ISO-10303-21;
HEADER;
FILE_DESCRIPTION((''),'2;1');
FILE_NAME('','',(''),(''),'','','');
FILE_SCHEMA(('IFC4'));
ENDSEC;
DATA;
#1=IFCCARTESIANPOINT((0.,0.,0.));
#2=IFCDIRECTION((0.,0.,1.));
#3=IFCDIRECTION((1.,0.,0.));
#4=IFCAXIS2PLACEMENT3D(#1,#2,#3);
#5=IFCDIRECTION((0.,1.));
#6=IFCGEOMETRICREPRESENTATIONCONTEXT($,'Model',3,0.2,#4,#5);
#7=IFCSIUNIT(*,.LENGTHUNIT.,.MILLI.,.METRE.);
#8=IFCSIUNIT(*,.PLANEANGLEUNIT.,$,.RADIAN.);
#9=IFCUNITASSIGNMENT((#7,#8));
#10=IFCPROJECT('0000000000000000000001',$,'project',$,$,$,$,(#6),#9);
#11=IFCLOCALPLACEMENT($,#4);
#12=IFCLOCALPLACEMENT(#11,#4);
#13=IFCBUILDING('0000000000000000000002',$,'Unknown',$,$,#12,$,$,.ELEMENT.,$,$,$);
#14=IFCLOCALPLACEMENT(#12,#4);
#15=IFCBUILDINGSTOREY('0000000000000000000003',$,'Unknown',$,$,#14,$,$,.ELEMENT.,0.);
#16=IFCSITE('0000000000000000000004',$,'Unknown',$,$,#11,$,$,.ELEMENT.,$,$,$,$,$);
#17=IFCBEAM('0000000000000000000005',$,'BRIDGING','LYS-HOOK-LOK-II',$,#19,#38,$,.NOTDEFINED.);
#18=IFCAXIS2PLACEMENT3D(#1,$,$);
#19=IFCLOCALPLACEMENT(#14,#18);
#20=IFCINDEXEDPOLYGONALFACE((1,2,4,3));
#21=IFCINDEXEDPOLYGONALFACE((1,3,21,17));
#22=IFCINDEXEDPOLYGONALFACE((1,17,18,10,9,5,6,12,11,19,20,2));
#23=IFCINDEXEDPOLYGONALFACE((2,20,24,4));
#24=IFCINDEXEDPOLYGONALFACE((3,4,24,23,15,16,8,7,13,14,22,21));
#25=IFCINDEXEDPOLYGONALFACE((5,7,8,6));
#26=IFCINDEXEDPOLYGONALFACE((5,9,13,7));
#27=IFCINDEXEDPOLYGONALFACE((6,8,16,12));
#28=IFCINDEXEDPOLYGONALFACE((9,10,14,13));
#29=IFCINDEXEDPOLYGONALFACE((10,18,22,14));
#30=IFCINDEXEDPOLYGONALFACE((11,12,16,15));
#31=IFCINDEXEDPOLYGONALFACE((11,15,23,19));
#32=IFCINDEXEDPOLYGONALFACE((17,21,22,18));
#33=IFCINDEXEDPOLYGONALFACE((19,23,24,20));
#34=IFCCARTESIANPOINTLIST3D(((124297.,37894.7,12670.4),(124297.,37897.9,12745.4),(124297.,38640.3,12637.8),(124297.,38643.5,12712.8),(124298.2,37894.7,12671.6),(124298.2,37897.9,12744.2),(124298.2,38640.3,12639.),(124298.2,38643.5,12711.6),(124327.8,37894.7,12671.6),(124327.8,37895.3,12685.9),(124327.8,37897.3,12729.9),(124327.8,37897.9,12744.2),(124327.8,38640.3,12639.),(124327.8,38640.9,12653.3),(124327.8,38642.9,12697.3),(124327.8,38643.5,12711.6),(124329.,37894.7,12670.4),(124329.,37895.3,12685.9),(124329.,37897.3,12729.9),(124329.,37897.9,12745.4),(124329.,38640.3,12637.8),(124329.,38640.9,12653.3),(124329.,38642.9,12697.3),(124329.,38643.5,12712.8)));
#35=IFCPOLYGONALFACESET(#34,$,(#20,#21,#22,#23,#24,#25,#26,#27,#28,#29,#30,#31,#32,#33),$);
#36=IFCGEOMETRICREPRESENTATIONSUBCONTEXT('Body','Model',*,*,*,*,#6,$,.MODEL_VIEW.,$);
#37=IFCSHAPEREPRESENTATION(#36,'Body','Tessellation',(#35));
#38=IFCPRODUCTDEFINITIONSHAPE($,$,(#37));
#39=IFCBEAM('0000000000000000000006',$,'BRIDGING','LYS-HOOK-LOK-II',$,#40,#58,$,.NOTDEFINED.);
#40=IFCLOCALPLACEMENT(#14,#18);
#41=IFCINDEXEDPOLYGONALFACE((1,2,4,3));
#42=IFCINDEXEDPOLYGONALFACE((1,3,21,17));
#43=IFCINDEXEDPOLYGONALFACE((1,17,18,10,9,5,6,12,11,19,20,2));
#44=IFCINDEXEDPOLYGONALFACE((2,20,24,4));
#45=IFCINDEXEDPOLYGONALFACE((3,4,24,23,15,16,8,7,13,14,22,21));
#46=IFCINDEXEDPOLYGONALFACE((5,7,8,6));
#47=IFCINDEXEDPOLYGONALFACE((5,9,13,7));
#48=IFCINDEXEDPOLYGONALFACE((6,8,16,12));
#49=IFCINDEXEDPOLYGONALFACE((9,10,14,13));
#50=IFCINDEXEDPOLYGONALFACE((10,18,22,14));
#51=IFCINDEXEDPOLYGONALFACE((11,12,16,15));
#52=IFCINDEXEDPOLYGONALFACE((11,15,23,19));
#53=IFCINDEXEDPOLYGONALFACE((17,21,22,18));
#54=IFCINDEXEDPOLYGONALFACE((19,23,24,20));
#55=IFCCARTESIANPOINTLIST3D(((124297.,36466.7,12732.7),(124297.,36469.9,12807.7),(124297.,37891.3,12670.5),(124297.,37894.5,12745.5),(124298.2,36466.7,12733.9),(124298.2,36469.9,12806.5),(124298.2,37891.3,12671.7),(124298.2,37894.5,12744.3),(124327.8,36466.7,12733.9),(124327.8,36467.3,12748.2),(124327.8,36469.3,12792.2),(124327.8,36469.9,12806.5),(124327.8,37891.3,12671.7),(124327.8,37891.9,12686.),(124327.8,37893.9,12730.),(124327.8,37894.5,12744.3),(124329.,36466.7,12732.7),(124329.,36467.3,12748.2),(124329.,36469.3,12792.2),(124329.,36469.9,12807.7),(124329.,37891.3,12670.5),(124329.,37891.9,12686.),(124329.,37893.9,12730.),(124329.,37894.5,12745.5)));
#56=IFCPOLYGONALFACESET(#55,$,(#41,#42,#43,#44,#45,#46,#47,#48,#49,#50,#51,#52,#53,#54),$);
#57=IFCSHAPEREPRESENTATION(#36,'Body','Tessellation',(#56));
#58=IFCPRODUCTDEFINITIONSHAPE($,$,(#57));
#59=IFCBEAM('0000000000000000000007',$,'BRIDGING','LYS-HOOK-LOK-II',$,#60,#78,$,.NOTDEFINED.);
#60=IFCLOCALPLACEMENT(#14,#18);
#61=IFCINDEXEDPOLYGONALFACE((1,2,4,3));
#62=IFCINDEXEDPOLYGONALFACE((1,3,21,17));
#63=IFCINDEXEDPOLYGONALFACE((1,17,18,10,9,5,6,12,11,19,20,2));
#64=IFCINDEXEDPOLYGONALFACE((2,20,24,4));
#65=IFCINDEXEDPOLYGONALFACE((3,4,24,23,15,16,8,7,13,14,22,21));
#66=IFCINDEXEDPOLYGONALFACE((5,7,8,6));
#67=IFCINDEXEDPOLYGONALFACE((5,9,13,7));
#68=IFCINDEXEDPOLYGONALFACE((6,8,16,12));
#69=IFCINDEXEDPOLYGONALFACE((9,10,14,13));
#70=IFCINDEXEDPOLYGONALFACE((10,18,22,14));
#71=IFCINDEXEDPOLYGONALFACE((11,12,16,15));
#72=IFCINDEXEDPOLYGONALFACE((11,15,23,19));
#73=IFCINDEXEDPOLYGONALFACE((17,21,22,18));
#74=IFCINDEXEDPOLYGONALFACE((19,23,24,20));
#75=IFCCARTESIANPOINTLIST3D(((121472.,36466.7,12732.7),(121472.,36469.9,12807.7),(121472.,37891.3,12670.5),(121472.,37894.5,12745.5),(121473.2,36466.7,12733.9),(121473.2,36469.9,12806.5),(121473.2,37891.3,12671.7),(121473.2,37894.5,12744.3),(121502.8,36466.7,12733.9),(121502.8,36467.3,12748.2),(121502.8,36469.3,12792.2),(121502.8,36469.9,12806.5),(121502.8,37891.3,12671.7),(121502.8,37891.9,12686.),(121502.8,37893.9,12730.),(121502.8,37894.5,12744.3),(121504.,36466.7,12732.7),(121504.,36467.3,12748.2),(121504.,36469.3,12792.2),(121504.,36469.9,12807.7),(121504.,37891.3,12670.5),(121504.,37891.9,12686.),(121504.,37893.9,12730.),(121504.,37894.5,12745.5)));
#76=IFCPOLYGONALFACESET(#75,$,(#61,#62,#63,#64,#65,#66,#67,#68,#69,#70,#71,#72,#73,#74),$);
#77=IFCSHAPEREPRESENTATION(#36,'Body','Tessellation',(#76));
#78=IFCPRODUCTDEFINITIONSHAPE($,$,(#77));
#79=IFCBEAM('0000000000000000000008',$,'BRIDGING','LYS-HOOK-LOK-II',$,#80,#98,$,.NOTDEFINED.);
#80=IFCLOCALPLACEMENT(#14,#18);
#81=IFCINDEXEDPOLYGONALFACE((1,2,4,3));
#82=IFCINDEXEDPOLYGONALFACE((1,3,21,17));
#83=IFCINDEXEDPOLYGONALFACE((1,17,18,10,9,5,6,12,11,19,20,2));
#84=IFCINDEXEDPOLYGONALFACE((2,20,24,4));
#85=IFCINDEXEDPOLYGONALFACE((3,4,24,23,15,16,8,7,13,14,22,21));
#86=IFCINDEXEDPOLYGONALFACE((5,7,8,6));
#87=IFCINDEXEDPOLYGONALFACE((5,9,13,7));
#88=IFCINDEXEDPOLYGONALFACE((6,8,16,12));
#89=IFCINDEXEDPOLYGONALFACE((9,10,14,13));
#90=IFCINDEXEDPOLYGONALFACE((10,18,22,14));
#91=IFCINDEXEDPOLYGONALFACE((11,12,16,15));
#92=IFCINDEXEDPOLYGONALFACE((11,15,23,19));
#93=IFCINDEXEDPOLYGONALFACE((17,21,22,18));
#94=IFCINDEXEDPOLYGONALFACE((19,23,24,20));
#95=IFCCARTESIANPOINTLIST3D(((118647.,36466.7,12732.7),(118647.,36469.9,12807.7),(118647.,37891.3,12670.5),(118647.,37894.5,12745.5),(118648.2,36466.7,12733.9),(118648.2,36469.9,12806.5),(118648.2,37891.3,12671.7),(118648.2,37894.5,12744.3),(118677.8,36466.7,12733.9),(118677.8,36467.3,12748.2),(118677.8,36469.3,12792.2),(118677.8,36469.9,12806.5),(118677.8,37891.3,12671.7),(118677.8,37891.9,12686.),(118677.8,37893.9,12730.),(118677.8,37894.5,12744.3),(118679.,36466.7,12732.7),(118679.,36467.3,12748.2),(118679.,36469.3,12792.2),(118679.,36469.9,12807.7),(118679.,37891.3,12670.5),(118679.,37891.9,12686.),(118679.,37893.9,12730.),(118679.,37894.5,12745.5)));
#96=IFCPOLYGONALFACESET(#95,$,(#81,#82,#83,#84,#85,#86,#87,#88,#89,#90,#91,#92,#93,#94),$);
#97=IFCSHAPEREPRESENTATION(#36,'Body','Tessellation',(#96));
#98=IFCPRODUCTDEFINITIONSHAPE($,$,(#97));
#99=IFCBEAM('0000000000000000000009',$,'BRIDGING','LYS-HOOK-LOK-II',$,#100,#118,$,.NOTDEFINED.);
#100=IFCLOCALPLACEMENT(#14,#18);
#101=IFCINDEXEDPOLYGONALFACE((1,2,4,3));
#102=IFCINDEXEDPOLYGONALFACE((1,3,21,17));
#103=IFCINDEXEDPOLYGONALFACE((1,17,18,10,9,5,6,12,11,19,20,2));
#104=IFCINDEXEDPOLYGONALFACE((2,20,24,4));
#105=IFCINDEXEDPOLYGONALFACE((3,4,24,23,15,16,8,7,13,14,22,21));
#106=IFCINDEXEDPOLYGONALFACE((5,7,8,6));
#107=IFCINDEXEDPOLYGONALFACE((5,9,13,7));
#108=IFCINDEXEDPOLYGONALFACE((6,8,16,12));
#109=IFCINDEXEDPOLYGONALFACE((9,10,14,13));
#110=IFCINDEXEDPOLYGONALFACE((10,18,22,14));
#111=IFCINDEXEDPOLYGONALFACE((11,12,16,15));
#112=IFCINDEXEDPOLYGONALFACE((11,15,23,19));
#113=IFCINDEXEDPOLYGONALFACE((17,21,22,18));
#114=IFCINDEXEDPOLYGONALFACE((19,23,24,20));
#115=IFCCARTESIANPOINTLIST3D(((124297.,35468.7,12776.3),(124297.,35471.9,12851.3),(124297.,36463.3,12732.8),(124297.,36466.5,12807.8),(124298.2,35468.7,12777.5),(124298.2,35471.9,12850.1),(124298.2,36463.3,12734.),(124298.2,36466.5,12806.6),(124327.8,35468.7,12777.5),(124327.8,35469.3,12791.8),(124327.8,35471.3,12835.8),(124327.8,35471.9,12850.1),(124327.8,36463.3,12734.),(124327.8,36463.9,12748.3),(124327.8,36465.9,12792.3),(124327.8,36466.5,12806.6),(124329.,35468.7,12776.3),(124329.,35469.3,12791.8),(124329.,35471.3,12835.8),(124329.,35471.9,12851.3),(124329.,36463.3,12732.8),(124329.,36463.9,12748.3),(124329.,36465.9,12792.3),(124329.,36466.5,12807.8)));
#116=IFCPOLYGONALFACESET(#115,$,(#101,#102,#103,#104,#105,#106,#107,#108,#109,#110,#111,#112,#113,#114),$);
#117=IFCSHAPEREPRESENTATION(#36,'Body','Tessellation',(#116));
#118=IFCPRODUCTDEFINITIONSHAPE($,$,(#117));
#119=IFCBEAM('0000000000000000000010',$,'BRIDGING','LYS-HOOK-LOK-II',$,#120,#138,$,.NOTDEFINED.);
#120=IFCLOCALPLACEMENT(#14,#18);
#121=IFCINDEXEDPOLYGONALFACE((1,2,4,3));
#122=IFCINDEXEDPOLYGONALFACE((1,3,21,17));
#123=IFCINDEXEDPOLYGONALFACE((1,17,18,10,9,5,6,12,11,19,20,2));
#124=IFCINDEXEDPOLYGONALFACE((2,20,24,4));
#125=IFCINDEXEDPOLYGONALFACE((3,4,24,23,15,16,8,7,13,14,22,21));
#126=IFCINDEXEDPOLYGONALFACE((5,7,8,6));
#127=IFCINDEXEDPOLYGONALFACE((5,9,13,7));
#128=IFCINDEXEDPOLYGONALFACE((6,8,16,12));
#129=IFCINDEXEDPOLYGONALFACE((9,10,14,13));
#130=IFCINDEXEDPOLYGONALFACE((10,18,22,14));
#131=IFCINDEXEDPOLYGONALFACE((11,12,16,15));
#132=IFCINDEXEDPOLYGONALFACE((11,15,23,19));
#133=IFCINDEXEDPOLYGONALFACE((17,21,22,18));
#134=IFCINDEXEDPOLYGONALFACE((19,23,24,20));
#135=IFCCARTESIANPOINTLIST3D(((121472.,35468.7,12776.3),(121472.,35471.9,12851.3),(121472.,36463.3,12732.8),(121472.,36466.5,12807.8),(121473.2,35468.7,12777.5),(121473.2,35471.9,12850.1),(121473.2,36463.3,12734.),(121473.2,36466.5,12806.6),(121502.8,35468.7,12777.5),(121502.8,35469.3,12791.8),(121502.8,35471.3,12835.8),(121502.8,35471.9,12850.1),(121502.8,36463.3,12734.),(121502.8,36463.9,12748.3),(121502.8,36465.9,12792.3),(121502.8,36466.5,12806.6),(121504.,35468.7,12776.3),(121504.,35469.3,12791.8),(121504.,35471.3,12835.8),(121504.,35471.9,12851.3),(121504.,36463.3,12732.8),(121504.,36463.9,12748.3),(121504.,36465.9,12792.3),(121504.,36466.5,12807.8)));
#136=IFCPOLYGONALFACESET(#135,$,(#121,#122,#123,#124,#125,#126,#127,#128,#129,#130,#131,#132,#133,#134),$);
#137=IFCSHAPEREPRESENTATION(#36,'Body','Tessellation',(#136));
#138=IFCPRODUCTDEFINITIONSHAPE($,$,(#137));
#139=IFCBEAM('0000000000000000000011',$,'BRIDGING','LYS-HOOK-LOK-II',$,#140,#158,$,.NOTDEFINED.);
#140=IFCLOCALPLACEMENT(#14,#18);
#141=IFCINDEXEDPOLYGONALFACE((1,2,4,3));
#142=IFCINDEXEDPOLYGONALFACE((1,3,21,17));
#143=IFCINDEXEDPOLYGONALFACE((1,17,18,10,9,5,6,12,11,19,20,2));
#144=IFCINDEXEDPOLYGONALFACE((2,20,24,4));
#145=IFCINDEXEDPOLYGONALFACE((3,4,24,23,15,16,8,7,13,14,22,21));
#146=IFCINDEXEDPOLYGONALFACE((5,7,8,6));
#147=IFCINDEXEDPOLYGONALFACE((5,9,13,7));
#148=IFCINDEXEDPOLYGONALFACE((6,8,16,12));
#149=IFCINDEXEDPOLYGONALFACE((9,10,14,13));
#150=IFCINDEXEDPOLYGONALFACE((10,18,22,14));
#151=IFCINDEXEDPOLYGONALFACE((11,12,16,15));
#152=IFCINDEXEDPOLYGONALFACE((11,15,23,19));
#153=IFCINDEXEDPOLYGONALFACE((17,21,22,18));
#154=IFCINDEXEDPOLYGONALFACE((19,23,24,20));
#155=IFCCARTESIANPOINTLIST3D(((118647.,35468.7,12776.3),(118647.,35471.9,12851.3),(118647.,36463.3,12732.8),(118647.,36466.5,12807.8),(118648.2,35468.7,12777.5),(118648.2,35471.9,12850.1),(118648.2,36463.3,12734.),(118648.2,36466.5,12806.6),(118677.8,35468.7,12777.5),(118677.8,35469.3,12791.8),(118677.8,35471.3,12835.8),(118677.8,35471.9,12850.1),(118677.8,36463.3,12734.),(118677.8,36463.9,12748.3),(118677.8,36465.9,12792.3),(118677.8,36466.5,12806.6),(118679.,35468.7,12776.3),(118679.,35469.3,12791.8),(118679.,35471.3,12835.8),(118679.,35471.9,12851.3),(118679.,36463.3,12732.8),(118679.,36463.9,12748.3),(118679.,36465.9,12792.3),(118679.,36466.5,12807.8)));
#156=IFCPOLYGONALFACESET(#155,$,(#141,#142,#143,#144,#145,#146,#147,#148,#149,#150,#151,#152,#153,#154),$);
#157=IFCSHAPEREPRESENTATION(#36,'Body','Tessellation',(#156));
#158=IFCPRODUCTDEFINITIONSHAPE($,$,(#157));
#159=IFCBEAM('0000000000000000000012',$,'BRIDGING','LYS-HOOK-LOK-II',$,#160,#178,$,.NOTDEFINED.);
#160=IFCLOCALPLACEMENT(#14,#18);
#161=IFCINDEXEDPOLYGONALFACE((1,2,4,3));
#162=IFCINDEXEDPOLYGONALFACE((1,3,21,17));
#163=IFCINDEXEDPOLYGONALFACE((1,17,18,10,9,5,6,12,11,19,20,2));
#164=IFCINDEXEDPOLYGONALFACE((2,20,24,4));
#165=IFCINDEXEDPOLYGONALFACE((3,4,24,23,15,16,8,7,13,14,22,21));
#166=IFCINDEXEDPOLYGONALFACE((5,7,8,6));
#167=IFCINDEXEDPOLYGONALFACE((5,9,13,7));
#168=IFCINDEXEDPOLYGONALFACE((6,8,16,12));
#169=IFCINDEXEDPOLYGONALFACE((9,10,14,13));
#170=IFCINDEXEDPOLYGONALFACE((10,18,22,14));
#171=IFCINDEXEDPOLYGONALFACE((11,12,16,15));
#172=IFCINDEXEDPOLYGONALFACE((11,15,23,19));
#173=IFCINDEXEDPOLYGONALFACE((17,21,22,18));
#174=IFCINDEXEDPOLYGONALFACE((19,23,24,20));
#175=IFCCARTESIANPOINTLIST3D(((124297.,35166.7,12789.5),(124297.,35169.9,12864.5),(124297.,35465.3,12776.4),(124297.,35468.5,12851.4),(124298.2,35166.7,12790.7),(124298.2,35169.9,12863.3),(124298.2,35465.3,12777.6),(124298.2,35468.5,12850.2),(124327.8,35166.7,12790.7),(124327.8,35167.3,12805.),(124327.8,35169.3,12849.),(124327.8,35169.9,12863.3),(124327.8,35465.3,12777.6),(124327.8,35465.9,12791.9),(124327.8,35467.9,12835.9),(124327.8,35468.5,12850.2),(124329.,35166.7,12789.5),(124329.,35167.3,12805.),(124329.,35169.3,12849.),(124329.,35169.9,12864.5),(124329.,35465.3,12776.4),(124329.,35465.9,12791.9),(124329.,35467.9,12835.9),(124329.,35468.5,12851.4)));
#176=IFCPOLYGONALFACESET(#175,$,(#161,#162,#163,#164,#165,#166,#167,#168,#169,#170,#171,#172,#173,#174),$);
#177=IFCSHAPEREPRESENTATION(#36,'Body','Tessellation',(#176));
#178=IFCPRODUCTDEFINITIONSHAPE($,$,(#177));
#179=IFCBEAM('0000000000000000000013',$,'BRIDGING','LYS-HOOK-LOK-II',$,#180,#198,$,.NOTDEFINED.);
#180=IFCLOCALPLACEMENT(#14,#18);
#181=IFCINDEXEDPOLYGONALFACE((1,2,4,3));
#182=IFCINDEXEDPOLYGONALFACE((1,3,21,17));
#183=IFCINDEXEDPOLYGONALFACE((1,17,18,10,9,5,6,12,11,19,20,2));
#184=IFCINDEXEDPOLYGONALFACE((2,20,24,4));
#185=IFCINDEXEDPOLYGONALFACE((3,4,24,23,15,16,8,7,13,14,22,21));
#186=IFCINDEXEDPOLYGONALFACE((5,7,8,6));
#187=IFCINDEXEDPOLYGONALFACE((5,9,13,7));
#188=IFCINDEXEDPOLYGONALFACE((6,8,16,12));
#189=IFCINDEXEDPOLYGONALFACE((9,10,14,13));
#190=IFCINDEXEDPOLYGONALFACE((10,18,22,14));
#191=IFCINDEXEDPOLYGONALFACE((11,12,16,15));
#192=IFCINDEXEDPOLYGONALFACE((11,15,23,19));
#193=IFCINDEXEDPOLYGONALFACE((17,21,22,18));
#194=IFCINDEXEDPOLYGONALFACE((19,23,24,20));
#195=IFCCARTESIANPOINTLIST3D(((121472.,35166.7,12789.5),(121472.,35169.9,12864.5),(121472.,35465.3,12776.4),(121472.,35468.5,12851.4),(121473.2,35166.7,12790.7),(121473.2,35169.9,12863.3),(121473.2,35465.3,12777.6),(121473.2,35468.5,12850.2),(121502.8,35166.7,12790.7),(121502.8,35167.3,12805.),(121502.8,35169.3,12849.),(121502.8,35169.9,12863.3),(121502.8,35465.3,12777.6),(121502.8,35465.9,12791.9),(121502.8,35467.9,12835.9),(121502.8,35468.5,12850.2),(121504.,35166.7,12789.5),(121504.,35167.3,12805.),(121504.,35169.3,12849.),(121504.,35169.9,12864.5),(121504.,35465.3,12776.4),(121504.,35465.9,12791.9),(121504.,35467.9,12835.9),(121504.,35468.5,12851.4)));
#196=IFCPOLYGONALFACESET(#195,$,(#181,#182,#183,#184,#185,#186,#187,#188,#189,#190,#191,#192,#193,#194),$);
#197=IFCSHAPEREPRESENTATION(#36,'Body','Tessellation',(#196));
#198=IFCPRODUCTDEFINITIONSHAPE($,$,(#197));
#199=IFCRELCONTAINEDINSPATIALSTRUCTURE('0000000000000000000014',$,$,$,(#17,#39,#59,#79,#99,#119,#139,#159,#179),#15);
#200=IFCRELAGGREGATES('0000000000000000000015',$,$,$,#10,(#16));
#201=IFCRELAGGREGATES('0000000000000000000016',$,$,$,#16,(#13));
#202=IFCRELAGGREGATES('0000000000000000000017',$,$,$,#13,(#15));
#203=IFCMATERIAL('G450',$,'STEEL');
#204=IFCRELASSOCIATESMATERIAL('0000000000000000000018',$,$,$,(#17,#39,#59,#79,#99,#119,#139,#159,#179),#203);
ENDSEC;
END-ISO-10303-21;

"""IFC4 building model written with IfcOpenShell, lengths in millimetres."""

from ifc_helpers import new_model, si_unit, direction, frame, origin_with_axes, place, context, subcontext, project, spatial, line, indexed_curve, outline, extrude, material, element, save


model = new_model("IFC4")

# Units and contexts
model_context = context("Model", 3, precision=0.2, world=origin_with_axes(), true_north=direction((0.0, 1.0)))
body_context = subcontext(model_context, "Body", "Model", "MODEL_VIEW")
ifc_project = project(units=[si_unit("LENGTHUNIT", "METRE", prefix="MILLI"), si_unit("PLANEANGLEUNIT", "RADIAN")], contexts=[model_context])

# Site, building, storey
site_placement = place(None, origin_with_axes())
site = spatial("IfcSite", under=ifc_project, at=site_placement, Name="Unknown", CompositionType="ELEMENT")
building_placement = place(site_placement, origin_with_axes())
building = spatial("IfcBuilding", under=site, at=building_placement, Name="Unknown", CompositionType="ELEMENT")
storey_placement = place(building_placement, origin_with_axes())
storey = spatial("IfcBuildingStorey", under=building, at=storey_placement, Name="Unknown", CompositionType="ELEMENT", Elevation=0.0)

# Beams
ifc_material_1 = material(Name="G450", Category="STEEL")
beam_placement = place(storey_placement, frame((124313.0, 37896.3, 12707.9), z_axis=(1.0, 0.0, 0.0), x_axis=(0.0, 0.999046, -0.043681)))
element("IfcBeam", 1, at=beam_placement, inside=storey, material=ifc_material_1, Name="BRIDGING", Description="LYS-HOOK-LOK-II", PredefinedType="NOTDEFINED", context=body_context, shape_type="SolidModel", body=[
    extrude(outline(indexed_curve([(16.0, -37.5), (16.0, -22.0), (14.8, -22.0), (14.8, -36.3), (-14.8, -36.3), (-14.8, 36.3), (14.8, 36.3), (14.8, 22.0), (16.0, 22.0), (16.0, 37.5), (-16.0, 37.5), (-16.0, -37.5)], segments=[line(1, 2, 3, 4, 5, 6, 7, 8, 9, 10, 11, 12, 1)])), frame((0.0, 0.0, 0.0), z_axis=(-1.0, 0.0, 0.0), x_axis=(0.0, 0.0, 1.0)), (0.0, 0.0, -1.0), 746.3),
])
for number, where, z_axis, x_axis, name in (
    (2, (124313.0, 36468.3, 12770.2), (1.0, 0.0, 0.0), (0.0, 0.999048, -0.04362), "BRIDGING"),
    (3, (121488.0, 36468.3, 12770.2), (1.0, 0.0, 0.0), (0.0, 0.999048, -0.04362), "BRIDGING"),
    (4, (118663.0, 36468.3, 12770.2), (1.0, 0.0, 0.0), (0.0, 0.999048, -0.04362), "BRIDGING"),
):
    element("IfcBeam", number, at=place(storey_placement, frame(where, z_axis=z_axis, x_axis=x_axis)), inside=storey, material=ifc_material_1, Name=name, Description="LYS-HOOK-LOK-II", PredefinedType="NOTDEFINED", context=body_context, shape_type="SolidModel", body=[
        extrude(outline(indexed_curve([(16.0, -37.5), (16.0, -22.0), (14.8, -22.0), (14.8, -36.3), (-14.8, -36.3), (-14.8, 36.3), (14.8, 36.3), (14.8, 22.0), (16.0, 22.0), (16.0, 37.5), (-16.0, 37.5), (-16.0, -37.5)], segments=[line(1, 2, 3, 4, 5, 6, 7, 8, 9, 10, 11, 12, 1)])), frame((0.0, 0.0, 0.0), z_axis=(-1.0, 0.0, 0.0), x_axis=(0.0, 0.0, 1.0)), (0.0, 0.0, -1.0), 1426.0),
    ])
for number, where, z_axis, x_axis, name in (
    (5, (124313.0, 35470.3, 12813.8), (1.0, 0.0, 0.0), (0.0, 0.999045, -0.043694), "BRIDGING"),
    (6, (121488.0, 35470.3, 12813.8), (1.0, 0.0, 0.0), (0.0, 0.999045, -0.043694), "BRIDGING"),
    (7, (118663.0, 35470.3, 12813.8), (1.0, 0.0, 0.0), (0.0, 0.999045, -0.043694), "BRIDGING"),
):
    element("IfcBeam", number, at=place(storey_placement, frame(where, z_axis=z_axis, x_axis=x_axis)), inside=storey, material=ifc_material_1, Name=name, Description="LYS-HOOK-LOK-II", PredefinedType="NOTDEFINED", context=body_context, shape_type="SolidModel", body=[
        extrude(outline(indexed_curve([(16.0, -37.5), (16.0, -22.0), (14.8, -22.0), (14.8, -36.3), (-14.8, -36.3), (-14.8, 36.3), (14.8, 36.3), (14.8, 22.0), (16.0, 22.0), (16.0, 37.5), (-16.0, 37.5), (-16.0, -37.5)], segments=[line(1, 2, 3, 4, 5, 6, 7, 8, 9, 10, 11, 12, 1)])), frame((0.0, 0.0, 0.0), z_axis=(-1.0, 0.0, 0.0), x_axis=(0.0, 0.0, 1.0)), (0.0, 0.0, -1.0), 995.6),
    ])
for number, where, z_axis, x_axis, name in (
    (8, (124313.0, 35168.3, 12827.0), (1.0, 0.0, 0.0), (0.0, 0.999039, -0.043829), "BRIDGING"),
    (9, (121488.0, 35168.3, 12827.0), (1.0, 0.0, 0.0), (0.0, 0.999039, -0.043829), "BRIDGING"),
):
    element("IfcBeam", number, at=place(storey_placement, frame(where, z_axis=z_axis, x_axis=x_axis)), inside=storey, material=ifc_material_1, Name=name, Description="LYS-HOOK-LOK-II", PredefinedType="NOTDEFINED", context=body_context, shape_type="SolidModel", body=[
        extrude(outline(indexed_curve([(16.0, -37.5), (16.0, -22.0), (14.8, -22.0), (14.8, -36.3), (-14.8, -36.3), (-14.8, 36.3), (14.8, 36.3), (14.8, 22.0), (16.0, 22.0), (16.0, 37.5), (-16.0, 37.5), (-16.0, -37.5)], segments=[line(1, 2, 3, 4, 5, 6, 7, 8, 9, 10, 11, 12, 1)])), frame((0.0, 0.0, 0.0), z_axis=(-1.0, 0.0, 0.0), x_axis=(0.0, 0.0, 1.0)), (0.0, 0.0, -1.0), 298.9),
    ])

save(model, "model.ifc")
